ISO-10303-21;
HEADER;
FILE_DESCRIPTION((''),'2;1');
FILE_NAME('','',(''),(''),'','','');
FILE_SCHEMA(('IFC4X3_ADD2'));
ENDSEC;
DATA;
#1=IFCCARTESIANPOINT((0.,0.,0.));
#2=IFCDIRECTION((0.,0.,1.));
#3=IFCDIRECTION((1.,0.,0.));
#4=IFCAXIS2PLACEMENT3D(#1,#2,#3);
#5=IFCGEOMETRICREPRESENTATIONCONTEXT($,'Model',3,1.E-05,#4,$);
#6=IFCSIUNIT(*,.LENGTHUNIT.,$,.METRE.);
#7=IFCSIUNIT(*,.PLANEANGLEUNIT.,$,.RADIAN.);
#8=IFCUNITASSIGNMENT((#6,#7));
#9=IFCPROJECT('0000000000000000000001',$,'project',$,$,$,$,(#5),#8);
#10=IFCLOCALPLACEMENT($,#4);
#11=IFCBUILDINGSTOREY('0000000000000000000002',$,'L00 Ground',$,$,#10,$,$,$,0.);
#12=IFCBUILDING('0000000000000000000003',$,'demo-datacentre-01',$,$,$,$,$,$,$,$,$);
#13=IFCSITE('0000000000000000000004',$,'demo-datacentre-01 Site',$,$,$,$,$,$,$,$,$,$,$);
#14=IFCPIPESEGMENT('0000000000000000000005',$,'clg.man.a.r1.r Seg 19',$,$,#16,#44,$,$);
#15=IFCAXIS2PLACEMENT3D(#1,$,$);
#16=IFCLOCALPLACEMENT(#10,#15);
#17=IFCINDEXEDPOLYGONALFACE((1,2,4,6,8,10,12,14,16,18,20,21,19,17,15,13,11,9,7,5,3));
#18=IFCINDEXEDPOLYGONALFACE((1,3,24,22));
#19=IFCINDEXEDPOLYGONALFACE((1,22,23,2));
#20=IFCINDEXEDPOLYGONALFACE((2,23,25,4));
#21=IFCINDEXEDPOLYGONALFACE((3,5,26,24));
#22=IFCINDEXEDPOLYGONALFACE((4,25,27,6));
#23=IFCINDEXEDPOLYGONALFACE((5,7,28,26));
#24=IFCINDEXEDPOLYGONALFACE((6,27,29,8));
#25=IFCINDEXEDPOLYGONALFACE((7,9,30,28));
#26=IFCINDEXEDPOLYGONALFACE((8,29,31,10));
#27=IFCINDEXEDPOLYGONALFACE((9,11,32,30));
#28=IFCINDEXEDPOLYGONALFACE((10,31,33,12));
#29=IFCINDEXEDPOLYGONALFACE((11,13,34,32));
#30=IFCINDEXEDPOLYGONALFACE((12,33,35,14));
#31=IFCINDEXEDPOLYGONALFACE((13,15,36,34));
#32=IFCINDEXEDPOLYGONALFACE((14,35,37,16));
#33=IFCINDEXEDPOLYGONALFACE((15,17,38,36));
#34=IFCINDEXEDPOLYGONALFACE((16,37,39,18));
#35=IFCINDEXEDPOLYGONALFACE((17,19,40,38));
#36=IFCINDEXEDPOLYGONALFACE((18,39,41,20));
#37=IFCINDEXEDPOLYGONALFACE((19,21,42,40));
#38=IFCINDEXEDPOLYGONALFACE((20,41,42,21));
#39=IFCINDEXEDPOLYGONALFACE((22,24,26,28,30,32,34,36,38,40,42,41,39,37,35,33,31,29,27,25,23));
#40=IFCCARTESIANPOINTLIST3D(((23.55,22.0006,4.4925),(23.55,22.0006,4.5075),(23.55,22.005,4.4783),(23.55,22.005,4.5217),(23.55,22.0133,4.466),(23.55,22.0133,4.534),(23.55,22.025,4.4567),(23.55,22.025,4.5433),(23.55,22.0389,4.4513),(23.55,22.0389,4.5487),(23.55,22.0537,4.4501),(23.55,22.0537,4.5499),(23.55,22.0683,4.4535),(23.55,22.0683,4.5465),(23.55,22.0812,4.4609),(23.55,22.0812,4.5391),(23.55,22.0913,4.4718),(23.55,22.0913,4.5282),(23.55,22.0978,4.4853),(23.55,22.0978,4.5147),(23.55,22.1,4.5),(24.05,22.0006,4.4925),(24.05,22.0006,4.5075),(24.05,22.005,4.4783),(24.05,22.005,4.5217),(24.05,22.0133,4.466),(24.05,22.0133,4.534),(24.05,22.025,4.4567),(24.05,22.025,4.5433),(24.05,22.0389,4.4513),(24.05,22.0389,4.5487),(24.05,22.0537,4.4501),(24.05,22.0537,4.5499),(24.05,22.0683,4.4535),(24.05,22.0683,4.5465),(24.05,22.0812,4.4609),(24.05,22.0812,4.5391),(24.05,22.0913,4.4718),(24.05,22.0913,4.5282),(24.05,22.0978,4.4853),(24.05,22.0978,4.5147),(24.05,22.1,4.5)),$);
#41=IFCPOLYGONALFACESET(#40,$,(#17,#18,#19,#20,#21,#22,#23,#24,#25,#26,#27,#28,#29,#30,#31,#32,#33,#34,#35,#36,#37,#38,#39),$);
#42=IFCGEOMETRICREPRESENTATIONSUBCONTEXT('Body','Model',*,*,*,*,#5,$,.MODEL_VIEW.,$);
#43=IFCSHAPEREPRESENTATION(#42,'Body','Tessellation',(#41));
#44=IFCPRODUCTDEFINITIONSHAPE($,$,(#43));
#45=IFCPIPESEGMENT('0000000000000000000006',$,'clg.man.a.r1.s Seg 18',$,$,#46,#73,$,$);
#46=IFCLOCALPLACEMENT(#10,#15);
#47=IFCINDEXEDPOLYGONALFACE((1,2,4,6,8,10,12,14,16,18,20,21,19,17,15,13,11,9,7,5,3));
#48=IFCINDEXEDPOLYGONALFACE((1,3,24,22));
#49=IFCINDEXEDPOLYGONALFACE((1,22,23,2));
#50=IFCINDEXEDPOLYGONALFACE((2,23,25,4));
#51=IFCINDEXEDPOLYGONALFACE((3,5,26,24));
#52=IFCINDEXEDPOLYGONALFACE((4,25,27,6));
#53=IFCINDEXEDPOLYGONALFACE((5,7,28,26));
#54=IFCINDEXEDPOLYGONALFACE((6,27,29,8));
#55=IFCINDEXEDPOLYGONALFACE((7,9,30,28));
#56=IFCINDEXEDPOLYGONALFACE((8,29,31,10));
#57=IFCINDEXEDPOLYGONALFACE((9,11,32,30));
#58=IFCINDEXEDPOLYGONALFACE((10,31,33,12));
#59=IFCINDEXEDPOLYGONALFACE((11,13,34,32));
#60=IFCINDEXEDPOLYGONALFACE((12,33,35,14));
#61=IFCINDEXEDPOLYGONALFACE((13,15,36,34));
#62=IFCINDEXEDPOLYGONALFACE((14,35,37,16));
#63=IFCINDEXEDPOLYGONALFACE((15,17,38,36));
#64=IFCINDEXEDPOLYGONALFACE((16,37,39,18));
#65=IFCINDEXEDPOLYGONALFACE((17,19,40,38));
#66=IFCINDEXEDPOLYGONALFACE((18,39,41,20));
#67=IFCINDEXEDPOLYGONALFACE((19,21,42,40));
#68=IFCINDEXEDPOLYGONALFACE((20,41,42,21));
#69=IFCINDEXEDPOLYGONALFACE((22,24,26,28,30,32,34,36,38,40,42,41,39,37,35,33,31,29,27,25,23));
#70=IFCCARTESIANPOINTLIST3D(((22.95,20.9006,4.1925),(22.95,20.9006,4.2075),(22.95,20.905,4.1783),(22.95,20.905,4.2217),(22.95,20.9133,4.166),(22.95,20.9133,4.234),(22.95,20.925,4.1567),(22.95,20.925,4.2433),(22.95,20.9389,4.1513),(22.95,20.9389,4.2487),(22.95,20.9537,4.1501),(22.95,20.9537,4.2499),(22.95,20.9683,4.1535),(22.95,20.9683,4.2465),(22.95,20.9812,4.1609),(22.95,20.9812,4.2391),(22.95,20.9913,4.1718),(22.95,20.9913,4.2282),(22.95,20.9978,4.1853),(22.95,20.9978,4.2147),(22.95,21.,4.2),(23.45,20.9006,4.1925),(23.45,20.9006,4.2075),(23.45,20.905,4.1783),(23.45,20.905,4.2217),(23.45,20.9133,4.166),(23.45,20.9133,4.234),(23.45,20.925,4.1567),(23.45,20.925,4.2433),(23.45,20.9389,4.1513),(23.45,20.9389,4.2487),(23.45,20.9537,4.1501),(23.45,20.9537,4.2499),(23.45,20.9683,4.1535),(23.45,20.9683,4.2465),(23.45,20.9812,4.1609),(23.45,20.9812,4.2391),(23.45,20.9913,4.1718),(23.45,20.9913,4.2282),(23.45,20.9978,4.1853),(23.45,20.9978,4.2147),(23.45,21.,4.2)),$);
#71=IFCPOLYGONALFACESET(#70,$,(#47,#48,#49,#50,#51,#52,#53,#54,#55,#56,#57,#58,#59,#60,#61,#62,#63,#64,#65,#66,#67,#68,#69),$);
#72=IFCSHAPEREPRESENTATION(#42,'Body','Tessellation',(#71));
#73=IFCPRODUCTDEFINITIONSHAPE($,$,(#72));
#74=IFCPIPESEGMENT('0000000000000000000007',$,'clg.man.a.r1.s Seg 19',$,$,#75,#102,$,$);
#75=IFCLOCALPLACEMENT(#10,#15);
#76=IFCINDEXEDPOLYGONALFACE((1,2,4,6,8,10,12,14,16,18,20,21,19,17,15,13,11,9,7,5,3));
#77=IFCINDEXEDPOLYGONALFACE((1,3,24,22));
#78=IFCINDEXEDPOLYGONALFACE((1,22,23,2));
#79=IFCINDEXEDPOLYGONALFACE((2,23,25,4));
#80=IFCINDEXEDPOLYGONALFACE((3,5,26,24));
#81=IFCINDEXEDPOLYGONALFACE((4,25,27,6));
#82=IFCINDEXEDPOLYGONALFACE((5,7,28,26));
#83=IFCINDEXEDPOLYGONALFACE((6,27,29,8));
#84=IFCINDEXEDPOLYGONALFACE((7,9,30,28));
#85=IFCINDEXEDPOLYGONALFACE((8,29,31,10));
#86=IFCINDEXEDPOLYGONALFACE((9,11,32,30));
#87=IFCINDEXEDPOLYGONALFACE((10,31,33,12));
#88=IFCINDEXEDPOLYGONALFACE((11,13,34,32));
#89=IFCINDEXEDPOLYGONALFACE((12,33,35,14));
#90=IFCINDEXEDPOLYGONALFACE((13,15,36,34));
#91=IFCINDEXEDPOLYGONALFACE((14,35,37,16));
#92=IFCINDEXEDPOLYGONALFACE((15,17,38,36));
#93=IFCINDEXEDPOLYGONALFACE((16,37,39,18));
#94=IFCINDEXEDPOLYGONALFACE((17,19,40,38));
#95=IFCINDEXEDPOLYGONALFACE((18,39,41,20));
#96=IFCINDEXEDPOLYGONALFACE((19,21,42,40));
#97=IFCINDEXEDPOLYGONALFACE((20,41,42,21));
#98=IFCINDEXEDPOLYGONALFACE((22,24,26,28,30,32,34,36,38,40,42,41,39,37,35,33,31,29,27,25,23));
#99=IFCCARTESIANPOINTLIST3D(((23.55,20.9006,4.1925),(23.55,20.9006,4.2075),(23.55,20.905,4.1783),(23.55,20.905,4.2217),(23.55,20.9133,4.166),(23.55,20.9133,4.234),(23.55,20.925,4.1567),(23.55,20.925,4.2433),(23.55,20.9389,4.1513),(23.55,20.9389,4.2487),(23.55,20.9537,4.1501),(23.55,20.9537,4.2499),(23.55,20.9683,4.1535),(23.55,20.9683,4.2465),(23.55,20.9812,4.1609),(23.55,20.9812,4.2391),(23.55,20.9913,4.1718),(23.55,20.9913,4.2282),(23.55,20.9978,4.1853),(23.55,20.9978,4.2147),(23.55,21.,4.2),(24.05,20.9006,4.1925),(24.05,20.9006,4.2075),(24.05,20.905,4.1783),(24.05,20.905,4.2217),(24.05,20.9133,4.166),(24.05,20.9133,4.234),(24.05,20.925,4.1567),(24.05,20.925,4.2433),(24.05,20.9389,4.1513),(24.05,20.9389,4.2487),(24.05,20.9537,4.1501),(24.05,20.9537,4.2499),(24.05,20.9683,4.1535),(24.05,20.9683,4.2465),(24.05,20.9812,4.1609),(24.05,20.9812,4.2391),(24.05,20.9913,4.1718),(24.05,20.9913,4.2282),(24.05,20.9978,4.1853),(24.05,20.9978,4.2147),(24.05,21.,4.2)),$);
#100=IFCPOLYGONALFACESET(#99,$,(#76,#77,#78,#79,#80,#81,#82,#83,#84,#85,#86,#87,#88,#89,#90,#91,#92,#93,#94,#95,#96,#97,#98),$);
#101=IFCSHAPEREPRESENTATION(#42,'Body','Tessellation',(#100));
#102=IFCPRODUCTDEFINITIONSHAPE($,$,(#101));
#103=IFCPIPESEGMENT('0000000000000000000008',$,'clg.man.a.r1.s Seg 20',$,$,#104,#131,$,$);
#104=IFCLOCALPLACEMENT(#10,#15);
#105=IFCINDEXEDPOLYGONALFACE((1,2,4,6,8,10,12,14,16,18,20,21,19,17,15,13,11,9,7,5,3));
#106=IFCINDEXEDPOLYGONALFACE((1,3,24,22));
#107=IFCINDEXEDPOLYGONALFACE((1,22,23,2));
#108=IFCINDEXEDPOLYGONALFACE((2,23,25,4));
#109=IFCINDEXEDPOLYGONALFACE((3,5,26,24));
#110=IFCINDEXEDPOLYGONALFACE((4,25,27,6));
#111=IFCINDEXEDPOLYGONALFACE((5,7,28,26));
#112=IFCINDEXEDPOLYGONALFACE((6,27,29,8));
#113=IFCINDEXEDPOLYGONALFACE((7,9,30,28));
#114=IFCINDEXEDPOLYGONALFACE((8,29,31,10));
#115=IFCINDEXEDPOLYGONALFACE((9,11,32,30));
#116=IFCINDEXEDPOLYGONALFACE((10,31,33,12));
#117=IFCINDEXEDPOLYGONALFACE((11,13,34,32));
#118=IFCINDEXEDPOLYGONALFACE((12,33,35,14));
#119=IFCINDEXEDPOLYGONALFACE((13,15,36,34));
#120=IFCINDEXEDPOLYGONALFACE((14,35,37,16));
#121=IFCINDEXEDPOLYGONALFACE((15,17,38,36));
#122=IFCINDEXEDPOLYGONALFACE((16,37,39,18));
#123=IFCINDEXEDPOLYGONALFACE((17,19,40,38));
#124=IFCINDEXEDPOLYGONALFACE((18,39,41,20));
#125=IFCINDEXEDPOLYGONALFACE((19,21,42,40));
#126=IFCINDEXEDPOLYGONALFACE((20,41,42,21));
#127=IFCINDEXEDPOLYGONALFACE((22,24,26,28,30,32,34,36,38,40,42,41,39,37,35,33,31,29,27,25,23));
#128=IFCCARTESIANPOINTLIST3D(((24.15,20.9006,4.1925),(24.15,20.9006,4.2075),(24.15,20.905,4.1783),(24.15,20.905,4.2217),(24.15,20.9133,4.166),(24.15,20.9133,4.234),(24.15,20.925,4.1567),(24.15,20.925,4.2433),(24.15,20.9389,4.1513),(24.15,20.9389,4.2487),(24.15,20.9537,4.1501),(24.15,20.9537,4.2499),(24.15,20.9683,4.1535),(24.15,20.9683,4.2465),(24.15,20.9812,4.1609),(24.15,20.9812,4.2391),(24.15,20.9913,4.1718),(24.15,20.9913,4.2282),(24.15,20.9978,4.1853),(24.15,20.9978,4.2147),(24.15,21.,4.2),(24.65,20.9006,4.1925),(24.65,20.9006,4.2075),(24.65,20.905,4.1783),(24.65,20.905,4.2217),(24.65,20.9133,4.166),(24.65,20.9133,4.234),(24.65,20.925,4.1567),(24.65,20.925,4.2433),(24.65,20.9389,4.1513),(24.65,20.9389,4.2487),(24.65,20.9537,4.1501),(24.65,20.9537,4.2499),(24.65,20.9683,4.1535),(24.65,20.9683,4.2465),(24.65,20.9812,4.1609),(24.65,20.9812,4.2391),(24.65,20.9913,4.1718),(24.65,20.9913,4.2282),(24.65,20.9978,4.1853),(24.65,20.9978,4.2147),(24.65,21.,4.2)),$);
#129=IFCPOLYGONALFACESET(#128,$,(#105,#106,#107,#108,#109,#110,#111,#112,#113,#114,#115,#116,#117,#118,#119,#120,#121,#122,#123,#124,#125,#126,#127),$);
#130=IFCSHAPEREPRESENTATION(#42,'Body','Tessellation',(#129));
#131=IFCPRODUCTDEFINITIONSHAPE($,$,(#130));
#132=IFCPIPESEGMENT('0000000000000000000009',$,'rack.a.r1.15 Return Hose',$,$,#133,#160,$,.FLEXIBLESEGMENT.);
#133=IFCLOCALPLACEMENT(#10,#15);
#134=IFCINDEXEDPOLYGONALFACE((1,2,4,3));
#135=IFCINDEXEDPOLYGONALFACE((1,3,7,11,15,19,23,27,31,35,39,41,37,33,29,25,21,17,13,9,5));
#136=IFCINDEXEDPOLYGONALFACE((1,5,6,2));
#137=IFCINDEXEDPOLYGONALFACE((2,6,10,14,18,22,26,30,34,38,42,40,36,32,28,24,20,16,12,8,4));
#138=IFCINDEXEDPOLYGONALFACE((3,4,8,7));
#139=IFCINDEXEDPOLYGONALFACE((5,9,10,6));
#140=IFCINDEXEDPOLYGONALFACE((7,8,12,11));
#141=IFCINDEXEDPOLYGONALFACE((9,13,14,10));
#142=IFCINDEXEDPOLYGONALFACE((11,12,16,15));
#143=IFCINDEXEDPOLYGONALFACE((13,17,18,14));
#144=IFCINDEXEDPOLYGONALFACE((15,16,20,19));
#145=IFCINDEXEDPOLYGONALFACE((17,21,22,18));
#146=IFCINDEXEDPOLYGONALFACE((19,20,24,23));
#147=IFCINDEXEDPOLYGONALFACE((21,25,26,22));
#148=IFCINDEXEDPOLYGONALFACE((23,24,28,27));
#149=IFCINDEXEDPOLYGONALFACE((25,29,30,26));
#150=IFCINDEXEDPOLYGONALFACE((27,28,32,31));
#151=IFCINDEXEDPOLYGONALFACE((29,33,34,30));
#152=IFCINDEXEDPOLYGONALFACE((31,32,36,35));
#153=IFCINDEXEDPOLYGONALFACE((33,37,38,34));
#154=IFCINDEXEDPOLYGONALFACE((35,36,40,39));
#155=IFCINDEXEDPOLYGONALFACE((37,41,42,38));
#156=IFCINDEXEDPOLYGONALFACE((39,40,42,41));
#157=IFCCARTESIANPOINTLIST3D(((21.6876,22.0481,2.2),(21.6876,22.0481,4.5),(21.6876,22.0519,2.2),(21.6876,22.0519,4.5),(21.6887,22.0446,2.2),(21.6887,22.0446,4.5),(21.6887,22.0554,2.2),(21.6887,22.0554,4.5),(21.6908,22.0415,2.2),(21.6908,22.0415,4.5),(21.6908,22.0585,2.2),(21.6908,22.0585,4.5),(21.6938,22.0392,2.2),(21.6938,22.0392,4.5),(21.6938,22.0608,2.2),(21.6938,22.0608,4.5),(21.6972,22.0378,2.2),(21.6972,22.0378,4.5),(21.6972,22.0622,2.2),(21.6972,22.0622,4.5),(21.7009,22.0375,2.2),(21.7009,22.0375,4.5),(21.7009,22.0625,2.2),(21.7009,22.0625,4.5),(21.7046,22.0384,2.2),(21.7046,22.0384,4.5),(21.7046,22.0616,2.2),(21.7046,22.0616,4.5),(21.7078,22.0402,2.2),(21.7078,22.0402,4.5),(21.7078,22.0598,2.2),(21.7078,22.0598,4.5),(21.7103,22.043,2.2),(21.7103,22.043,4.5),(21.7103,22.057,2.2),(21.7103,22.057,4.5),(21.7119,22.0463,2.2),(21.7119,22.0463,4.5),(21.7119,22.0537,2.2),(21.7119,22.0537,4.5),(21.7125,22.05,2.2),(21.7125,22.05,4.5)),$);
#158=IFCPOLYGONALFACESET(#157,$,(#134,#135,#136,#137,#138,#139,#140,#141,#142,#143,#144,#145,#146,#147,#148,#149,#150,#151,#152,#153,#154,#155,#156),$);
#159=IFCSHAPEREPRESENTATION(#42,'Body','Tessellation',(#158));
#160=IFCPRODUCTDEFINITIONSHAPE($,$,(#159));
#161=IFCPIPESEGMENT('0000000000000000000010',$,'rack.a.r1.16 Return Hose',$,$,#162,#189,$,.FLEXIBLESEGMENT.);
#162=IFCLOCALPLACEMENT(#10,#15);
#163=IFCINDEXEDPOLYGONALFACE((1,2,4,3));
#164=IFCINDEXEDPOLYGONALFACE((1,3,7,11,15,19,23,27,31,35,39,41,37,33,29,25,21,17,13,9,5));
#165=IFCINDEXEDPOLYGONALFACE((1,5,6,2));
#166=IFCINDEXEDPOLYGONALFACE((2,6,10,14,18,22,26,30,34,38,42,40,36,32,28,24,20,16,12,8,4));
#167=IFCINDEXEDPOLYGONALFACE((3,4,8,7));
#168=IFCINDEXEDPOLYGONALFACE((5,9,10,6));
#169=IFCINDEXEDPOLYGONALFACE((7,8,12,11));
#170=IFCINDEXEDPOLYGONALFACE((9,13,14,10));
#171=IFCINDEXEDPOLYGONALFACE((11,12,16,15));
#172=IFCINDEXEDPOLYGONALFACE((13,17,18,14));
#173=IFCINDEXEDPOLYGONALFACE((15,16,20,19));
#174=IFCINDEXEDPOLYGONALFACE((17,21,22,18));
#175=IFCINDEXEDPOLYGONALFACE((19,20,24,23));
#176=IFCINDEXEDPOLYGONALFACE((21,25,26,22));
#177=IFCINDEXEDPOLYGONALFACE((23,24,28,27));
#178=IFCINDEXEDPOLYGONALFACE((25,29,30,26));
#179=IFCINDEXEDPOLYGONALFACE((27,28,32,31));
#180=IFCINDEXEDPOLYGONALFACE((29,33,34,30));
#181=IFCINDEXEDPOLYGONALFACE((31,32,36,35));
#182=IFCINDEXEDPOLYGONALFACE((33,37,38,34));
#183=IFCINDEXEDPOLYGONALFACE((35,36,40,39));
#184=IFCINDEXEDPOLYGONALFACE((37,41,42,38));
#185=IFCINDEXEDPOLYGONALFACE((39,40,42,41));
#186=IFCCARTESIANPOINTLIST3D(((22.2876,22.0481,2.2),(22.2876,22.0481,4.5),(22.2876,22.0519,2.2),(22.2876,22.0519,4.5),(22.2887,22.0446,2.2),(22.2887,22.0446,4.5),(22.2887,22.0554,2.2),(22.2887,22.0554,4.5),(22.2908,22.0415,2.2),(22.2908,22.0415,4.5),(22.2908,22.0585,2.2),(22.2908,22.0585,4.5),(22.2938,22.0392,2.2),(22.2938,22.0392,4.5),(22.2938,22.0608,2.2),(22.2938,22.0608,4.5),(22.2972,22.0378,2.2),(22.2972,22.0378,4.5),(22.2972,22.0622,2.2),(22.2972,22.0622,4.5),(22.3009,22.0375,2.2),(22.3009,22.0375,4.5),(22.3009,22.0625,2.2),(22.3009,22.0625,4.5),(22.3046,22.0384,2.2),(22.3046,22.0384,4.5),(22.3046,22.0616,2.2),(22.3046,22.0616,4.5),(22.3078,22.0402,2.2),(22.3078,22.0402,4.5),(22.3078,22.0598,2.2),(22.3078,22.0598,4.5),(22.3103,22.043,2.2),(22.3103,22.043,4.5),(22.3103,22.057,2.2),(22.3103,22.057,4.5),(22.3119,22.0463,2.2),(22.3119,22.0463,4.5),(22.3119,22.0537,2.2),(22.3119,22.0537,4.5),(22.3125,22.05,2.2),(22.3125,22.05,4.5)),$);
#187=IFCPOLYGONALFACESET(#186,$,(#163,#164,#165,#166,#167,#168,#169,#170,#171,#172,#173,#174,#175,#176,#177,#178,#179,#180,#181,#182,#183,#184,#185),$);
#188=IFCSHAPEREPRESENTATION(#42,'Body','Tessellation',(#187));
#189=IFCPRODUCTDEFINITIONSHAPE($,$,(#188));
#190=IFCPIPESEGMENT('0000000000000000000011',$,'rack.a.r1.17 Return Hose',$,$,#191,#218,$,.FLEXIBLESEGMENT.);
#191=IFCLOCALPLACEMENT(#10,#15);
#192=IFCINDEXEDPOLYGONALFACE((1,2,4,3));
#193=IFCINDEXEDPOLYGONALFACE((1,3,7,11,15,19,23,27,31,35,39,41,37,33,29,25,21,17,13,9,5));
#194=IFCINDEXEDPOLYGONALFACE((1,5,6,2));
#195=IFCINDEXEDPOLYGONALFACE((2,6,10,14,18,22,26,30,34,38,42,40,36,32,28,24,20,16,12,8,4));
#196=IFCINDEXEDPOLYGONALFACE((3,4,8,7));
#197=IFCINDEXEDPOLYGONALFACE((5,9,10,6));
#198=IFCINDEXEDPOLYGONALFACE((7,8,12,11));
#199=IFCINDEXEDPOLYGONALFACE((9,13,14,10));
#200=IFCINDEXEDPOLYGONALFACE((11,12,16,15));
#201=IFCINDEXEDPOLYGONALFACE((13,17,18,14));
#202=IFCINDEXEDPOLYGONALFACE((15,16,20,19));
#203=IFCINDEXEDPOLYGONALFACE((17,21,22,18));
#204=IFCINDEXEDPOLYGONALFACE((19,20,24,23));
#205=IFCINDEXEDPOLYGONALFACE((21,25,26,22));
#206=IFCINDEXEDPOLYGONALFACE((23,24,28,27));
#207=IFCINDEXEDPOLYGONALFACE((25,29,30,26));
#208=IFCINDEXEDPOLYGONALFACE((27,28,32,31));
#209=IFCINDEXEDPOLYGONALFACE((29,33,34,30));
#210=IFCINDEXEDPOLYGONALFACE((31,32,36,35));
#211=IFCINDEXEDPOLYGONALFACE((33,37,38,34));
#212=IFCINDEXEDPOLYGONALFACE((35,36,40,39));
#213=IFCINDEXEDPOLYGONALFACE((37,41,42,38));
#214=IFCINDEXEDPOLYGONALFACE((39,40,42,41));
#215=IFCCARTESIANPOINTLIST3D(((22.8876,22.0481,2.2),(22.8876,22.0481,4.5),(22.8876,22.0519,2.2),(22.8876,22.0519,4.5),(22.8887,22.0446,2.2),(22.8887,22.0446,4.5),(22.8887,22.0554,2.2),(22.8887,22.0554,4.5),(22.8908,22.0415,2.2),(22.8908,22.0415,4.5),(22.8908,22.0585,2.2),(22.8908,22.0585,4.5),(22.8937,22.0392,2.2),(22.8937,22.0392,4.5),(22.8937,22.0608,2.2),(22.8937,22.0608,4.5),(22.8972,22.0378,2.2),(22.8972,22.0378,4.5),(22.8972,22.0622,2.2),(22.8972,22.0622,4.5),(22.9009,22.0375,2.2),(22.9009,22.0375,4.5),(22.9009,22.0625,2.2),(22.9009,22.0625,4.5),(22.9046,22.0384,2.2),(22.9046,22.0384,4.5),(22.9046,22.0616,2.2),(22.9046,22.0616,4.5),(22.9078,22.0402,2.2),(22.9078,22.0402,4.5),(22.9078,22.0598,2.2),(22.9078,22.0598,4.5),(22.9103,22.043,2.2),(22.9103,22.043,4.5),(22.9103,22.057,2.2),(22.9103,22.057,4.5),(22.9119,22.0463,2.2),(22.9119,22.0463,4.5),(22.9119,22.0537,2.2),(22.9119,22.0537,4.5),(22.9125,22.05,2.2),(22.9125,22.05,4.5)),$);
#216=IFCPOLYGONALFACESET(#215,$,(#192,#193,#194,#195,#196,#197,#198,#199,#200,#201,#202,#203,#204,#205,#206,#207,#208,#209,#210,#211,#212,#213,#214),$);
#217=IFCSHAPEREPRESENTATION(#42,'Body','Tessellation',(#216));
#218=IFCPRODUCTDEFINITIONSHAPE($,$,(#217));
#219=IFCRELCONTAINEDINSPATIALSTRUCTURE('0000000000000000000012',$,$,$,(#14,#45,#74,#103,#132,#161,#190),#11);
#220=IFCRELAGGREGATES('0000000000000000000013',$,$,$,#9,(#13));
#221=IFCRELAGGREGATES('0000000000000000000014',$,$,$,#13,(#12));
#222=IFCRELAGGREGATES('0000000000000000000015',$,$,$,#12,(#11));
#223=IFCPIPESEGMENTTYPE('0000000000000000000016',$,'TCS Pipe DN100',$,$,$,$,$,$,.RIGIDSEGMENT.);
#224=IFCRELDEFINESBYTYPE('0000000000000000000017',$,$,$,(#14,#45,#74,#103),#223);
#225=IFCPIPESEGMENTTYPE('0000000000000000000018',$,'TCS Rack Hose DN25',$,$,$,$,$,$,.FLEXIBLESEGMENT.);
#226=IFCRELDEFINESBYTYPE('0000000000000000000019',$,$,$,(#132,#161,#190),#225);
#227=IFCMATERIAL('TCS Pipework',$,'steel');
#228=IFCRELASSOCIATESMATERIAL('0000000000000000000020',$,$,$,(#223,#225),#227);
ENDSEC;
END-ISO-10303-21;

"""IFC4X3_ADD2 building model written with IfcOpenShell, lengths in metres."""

from ifc_helpers import new_model, si_unit, frame, origin_with_axes, place, context, subcontext, project, spatial, circle, extrude, material, type_object, element, save


model = new_model("IFC4X3_ADD2")

# Units and contexts
model_context = context("Model", 3, precision=1e-05, world=origin_with_axes())
body_context = subcontext(model_context, "Body", "Model", "MODEL_VIEW")
ifc_project = project(units=[si_unit("LENGTHUNIT", "METRE"), si_unit("PLANEANGLEUNIT", "RADIAN")], contexts=[model_context])

# Site, building, storey
site = spatial("IfcSite", under=ifc_project, Name="demo-datacentre-01 Site")
building = spatial("IfcBuilding", under=site, Name="demo-datacentre-01")
storey_placement = place(None, origin_with_axes())
storey = spatial("IfcBuildingStorey", under=building, at=storey_placement, Name="L00 Ground", Elevation=0.0)

# Shared definitions
ifc_material = material(Name="TCS Pipework", Category="steel")

# Pipe segments
pipe_segment_type_1 = type_object("IfcPipeSegmentType", Name="TCS Pipe DN100", PredefinedType="RIGIDSEGMENT", material=ifc_material)
for number, where, z_axis, x_axis, name in (
    (1, (23.55, 22.05, 4.5), (1.0, 0.0, 0.0), (0.0, 1.0, 0.0), "clg.man.a.r1.r Seg 19"),
    (2, (22.95, 20.95, 4.2), (1.0, 0.0, 0.0), (0.0, 1.0, 0.0), "clg.man.a.r1.s Seg 18"),
    (3, (23.55, 20.95, 4.2), (1.0, 0.0, 0.0), (0.0, 1.0, 0.0), "clg.man.a.r1.s Seg 19"),
    (4, (24.15, 20.95, 4.2), (1.0, 0.0, 0.0), (0.0, 1.0, 0.0), "clg.man.a.r1.s Seg 20"),
):
    element("IfcPipeSegment", number, at=place(storey_placement, frame(where, z_axis=z_axis, x_axis=x_axis)), inside=storey, type_object=pipe_segment_type_1, Name=name, context=body_context, shape_type="SweptSolid", body=[
        extrude(circle(Radius=0.05), origin_with_axes(), (0.0, 0.0, 1.0), 0.5),
    ])
pipe_segment_type_2 = type_object("IfcPipeSegmentType", Name="TCS Rack Hose DN25", PredefinedType="FLEXIBLESEGMENT", material=ifc_material)
for number, where, z_axis, x_axis, name in (
    (5, (21.7, 22.05, 4.5), (0.0, 0.0, -1.0), (1.0, 0.0, 0.0), "rack.a.r1.15 Return Hose"),
    (6, (22.3, 22.05, 4.5), (0.0, 0.0, -1.0), (1.0, 0.0, 0.0), "rack.a.r1.16 Return Hose"),
    (7, (22.9, 22.05, 4.5), (0.0, 0.0, -1.0), (1.0, 0.0, 0.0), "rack.a.r1.17 Return Hose"),
):
    element("IfcPipeSegment", number, at=place(storey_placement, frame(where, z_axis=z_axis, x_axis=x_axis)), inside=storey, type_object=pipe_segment_type_2, Name=name, PredefinedType="FLEXIBLESEGMENT", context=body_context, shape_type="SweptSolid", body=[
        extrude(circle(Radius=0.0125), origin_with_axes(), (0.0, 0.0, 1.0), 2.3),
    ])

save(model, "model.ifc")
